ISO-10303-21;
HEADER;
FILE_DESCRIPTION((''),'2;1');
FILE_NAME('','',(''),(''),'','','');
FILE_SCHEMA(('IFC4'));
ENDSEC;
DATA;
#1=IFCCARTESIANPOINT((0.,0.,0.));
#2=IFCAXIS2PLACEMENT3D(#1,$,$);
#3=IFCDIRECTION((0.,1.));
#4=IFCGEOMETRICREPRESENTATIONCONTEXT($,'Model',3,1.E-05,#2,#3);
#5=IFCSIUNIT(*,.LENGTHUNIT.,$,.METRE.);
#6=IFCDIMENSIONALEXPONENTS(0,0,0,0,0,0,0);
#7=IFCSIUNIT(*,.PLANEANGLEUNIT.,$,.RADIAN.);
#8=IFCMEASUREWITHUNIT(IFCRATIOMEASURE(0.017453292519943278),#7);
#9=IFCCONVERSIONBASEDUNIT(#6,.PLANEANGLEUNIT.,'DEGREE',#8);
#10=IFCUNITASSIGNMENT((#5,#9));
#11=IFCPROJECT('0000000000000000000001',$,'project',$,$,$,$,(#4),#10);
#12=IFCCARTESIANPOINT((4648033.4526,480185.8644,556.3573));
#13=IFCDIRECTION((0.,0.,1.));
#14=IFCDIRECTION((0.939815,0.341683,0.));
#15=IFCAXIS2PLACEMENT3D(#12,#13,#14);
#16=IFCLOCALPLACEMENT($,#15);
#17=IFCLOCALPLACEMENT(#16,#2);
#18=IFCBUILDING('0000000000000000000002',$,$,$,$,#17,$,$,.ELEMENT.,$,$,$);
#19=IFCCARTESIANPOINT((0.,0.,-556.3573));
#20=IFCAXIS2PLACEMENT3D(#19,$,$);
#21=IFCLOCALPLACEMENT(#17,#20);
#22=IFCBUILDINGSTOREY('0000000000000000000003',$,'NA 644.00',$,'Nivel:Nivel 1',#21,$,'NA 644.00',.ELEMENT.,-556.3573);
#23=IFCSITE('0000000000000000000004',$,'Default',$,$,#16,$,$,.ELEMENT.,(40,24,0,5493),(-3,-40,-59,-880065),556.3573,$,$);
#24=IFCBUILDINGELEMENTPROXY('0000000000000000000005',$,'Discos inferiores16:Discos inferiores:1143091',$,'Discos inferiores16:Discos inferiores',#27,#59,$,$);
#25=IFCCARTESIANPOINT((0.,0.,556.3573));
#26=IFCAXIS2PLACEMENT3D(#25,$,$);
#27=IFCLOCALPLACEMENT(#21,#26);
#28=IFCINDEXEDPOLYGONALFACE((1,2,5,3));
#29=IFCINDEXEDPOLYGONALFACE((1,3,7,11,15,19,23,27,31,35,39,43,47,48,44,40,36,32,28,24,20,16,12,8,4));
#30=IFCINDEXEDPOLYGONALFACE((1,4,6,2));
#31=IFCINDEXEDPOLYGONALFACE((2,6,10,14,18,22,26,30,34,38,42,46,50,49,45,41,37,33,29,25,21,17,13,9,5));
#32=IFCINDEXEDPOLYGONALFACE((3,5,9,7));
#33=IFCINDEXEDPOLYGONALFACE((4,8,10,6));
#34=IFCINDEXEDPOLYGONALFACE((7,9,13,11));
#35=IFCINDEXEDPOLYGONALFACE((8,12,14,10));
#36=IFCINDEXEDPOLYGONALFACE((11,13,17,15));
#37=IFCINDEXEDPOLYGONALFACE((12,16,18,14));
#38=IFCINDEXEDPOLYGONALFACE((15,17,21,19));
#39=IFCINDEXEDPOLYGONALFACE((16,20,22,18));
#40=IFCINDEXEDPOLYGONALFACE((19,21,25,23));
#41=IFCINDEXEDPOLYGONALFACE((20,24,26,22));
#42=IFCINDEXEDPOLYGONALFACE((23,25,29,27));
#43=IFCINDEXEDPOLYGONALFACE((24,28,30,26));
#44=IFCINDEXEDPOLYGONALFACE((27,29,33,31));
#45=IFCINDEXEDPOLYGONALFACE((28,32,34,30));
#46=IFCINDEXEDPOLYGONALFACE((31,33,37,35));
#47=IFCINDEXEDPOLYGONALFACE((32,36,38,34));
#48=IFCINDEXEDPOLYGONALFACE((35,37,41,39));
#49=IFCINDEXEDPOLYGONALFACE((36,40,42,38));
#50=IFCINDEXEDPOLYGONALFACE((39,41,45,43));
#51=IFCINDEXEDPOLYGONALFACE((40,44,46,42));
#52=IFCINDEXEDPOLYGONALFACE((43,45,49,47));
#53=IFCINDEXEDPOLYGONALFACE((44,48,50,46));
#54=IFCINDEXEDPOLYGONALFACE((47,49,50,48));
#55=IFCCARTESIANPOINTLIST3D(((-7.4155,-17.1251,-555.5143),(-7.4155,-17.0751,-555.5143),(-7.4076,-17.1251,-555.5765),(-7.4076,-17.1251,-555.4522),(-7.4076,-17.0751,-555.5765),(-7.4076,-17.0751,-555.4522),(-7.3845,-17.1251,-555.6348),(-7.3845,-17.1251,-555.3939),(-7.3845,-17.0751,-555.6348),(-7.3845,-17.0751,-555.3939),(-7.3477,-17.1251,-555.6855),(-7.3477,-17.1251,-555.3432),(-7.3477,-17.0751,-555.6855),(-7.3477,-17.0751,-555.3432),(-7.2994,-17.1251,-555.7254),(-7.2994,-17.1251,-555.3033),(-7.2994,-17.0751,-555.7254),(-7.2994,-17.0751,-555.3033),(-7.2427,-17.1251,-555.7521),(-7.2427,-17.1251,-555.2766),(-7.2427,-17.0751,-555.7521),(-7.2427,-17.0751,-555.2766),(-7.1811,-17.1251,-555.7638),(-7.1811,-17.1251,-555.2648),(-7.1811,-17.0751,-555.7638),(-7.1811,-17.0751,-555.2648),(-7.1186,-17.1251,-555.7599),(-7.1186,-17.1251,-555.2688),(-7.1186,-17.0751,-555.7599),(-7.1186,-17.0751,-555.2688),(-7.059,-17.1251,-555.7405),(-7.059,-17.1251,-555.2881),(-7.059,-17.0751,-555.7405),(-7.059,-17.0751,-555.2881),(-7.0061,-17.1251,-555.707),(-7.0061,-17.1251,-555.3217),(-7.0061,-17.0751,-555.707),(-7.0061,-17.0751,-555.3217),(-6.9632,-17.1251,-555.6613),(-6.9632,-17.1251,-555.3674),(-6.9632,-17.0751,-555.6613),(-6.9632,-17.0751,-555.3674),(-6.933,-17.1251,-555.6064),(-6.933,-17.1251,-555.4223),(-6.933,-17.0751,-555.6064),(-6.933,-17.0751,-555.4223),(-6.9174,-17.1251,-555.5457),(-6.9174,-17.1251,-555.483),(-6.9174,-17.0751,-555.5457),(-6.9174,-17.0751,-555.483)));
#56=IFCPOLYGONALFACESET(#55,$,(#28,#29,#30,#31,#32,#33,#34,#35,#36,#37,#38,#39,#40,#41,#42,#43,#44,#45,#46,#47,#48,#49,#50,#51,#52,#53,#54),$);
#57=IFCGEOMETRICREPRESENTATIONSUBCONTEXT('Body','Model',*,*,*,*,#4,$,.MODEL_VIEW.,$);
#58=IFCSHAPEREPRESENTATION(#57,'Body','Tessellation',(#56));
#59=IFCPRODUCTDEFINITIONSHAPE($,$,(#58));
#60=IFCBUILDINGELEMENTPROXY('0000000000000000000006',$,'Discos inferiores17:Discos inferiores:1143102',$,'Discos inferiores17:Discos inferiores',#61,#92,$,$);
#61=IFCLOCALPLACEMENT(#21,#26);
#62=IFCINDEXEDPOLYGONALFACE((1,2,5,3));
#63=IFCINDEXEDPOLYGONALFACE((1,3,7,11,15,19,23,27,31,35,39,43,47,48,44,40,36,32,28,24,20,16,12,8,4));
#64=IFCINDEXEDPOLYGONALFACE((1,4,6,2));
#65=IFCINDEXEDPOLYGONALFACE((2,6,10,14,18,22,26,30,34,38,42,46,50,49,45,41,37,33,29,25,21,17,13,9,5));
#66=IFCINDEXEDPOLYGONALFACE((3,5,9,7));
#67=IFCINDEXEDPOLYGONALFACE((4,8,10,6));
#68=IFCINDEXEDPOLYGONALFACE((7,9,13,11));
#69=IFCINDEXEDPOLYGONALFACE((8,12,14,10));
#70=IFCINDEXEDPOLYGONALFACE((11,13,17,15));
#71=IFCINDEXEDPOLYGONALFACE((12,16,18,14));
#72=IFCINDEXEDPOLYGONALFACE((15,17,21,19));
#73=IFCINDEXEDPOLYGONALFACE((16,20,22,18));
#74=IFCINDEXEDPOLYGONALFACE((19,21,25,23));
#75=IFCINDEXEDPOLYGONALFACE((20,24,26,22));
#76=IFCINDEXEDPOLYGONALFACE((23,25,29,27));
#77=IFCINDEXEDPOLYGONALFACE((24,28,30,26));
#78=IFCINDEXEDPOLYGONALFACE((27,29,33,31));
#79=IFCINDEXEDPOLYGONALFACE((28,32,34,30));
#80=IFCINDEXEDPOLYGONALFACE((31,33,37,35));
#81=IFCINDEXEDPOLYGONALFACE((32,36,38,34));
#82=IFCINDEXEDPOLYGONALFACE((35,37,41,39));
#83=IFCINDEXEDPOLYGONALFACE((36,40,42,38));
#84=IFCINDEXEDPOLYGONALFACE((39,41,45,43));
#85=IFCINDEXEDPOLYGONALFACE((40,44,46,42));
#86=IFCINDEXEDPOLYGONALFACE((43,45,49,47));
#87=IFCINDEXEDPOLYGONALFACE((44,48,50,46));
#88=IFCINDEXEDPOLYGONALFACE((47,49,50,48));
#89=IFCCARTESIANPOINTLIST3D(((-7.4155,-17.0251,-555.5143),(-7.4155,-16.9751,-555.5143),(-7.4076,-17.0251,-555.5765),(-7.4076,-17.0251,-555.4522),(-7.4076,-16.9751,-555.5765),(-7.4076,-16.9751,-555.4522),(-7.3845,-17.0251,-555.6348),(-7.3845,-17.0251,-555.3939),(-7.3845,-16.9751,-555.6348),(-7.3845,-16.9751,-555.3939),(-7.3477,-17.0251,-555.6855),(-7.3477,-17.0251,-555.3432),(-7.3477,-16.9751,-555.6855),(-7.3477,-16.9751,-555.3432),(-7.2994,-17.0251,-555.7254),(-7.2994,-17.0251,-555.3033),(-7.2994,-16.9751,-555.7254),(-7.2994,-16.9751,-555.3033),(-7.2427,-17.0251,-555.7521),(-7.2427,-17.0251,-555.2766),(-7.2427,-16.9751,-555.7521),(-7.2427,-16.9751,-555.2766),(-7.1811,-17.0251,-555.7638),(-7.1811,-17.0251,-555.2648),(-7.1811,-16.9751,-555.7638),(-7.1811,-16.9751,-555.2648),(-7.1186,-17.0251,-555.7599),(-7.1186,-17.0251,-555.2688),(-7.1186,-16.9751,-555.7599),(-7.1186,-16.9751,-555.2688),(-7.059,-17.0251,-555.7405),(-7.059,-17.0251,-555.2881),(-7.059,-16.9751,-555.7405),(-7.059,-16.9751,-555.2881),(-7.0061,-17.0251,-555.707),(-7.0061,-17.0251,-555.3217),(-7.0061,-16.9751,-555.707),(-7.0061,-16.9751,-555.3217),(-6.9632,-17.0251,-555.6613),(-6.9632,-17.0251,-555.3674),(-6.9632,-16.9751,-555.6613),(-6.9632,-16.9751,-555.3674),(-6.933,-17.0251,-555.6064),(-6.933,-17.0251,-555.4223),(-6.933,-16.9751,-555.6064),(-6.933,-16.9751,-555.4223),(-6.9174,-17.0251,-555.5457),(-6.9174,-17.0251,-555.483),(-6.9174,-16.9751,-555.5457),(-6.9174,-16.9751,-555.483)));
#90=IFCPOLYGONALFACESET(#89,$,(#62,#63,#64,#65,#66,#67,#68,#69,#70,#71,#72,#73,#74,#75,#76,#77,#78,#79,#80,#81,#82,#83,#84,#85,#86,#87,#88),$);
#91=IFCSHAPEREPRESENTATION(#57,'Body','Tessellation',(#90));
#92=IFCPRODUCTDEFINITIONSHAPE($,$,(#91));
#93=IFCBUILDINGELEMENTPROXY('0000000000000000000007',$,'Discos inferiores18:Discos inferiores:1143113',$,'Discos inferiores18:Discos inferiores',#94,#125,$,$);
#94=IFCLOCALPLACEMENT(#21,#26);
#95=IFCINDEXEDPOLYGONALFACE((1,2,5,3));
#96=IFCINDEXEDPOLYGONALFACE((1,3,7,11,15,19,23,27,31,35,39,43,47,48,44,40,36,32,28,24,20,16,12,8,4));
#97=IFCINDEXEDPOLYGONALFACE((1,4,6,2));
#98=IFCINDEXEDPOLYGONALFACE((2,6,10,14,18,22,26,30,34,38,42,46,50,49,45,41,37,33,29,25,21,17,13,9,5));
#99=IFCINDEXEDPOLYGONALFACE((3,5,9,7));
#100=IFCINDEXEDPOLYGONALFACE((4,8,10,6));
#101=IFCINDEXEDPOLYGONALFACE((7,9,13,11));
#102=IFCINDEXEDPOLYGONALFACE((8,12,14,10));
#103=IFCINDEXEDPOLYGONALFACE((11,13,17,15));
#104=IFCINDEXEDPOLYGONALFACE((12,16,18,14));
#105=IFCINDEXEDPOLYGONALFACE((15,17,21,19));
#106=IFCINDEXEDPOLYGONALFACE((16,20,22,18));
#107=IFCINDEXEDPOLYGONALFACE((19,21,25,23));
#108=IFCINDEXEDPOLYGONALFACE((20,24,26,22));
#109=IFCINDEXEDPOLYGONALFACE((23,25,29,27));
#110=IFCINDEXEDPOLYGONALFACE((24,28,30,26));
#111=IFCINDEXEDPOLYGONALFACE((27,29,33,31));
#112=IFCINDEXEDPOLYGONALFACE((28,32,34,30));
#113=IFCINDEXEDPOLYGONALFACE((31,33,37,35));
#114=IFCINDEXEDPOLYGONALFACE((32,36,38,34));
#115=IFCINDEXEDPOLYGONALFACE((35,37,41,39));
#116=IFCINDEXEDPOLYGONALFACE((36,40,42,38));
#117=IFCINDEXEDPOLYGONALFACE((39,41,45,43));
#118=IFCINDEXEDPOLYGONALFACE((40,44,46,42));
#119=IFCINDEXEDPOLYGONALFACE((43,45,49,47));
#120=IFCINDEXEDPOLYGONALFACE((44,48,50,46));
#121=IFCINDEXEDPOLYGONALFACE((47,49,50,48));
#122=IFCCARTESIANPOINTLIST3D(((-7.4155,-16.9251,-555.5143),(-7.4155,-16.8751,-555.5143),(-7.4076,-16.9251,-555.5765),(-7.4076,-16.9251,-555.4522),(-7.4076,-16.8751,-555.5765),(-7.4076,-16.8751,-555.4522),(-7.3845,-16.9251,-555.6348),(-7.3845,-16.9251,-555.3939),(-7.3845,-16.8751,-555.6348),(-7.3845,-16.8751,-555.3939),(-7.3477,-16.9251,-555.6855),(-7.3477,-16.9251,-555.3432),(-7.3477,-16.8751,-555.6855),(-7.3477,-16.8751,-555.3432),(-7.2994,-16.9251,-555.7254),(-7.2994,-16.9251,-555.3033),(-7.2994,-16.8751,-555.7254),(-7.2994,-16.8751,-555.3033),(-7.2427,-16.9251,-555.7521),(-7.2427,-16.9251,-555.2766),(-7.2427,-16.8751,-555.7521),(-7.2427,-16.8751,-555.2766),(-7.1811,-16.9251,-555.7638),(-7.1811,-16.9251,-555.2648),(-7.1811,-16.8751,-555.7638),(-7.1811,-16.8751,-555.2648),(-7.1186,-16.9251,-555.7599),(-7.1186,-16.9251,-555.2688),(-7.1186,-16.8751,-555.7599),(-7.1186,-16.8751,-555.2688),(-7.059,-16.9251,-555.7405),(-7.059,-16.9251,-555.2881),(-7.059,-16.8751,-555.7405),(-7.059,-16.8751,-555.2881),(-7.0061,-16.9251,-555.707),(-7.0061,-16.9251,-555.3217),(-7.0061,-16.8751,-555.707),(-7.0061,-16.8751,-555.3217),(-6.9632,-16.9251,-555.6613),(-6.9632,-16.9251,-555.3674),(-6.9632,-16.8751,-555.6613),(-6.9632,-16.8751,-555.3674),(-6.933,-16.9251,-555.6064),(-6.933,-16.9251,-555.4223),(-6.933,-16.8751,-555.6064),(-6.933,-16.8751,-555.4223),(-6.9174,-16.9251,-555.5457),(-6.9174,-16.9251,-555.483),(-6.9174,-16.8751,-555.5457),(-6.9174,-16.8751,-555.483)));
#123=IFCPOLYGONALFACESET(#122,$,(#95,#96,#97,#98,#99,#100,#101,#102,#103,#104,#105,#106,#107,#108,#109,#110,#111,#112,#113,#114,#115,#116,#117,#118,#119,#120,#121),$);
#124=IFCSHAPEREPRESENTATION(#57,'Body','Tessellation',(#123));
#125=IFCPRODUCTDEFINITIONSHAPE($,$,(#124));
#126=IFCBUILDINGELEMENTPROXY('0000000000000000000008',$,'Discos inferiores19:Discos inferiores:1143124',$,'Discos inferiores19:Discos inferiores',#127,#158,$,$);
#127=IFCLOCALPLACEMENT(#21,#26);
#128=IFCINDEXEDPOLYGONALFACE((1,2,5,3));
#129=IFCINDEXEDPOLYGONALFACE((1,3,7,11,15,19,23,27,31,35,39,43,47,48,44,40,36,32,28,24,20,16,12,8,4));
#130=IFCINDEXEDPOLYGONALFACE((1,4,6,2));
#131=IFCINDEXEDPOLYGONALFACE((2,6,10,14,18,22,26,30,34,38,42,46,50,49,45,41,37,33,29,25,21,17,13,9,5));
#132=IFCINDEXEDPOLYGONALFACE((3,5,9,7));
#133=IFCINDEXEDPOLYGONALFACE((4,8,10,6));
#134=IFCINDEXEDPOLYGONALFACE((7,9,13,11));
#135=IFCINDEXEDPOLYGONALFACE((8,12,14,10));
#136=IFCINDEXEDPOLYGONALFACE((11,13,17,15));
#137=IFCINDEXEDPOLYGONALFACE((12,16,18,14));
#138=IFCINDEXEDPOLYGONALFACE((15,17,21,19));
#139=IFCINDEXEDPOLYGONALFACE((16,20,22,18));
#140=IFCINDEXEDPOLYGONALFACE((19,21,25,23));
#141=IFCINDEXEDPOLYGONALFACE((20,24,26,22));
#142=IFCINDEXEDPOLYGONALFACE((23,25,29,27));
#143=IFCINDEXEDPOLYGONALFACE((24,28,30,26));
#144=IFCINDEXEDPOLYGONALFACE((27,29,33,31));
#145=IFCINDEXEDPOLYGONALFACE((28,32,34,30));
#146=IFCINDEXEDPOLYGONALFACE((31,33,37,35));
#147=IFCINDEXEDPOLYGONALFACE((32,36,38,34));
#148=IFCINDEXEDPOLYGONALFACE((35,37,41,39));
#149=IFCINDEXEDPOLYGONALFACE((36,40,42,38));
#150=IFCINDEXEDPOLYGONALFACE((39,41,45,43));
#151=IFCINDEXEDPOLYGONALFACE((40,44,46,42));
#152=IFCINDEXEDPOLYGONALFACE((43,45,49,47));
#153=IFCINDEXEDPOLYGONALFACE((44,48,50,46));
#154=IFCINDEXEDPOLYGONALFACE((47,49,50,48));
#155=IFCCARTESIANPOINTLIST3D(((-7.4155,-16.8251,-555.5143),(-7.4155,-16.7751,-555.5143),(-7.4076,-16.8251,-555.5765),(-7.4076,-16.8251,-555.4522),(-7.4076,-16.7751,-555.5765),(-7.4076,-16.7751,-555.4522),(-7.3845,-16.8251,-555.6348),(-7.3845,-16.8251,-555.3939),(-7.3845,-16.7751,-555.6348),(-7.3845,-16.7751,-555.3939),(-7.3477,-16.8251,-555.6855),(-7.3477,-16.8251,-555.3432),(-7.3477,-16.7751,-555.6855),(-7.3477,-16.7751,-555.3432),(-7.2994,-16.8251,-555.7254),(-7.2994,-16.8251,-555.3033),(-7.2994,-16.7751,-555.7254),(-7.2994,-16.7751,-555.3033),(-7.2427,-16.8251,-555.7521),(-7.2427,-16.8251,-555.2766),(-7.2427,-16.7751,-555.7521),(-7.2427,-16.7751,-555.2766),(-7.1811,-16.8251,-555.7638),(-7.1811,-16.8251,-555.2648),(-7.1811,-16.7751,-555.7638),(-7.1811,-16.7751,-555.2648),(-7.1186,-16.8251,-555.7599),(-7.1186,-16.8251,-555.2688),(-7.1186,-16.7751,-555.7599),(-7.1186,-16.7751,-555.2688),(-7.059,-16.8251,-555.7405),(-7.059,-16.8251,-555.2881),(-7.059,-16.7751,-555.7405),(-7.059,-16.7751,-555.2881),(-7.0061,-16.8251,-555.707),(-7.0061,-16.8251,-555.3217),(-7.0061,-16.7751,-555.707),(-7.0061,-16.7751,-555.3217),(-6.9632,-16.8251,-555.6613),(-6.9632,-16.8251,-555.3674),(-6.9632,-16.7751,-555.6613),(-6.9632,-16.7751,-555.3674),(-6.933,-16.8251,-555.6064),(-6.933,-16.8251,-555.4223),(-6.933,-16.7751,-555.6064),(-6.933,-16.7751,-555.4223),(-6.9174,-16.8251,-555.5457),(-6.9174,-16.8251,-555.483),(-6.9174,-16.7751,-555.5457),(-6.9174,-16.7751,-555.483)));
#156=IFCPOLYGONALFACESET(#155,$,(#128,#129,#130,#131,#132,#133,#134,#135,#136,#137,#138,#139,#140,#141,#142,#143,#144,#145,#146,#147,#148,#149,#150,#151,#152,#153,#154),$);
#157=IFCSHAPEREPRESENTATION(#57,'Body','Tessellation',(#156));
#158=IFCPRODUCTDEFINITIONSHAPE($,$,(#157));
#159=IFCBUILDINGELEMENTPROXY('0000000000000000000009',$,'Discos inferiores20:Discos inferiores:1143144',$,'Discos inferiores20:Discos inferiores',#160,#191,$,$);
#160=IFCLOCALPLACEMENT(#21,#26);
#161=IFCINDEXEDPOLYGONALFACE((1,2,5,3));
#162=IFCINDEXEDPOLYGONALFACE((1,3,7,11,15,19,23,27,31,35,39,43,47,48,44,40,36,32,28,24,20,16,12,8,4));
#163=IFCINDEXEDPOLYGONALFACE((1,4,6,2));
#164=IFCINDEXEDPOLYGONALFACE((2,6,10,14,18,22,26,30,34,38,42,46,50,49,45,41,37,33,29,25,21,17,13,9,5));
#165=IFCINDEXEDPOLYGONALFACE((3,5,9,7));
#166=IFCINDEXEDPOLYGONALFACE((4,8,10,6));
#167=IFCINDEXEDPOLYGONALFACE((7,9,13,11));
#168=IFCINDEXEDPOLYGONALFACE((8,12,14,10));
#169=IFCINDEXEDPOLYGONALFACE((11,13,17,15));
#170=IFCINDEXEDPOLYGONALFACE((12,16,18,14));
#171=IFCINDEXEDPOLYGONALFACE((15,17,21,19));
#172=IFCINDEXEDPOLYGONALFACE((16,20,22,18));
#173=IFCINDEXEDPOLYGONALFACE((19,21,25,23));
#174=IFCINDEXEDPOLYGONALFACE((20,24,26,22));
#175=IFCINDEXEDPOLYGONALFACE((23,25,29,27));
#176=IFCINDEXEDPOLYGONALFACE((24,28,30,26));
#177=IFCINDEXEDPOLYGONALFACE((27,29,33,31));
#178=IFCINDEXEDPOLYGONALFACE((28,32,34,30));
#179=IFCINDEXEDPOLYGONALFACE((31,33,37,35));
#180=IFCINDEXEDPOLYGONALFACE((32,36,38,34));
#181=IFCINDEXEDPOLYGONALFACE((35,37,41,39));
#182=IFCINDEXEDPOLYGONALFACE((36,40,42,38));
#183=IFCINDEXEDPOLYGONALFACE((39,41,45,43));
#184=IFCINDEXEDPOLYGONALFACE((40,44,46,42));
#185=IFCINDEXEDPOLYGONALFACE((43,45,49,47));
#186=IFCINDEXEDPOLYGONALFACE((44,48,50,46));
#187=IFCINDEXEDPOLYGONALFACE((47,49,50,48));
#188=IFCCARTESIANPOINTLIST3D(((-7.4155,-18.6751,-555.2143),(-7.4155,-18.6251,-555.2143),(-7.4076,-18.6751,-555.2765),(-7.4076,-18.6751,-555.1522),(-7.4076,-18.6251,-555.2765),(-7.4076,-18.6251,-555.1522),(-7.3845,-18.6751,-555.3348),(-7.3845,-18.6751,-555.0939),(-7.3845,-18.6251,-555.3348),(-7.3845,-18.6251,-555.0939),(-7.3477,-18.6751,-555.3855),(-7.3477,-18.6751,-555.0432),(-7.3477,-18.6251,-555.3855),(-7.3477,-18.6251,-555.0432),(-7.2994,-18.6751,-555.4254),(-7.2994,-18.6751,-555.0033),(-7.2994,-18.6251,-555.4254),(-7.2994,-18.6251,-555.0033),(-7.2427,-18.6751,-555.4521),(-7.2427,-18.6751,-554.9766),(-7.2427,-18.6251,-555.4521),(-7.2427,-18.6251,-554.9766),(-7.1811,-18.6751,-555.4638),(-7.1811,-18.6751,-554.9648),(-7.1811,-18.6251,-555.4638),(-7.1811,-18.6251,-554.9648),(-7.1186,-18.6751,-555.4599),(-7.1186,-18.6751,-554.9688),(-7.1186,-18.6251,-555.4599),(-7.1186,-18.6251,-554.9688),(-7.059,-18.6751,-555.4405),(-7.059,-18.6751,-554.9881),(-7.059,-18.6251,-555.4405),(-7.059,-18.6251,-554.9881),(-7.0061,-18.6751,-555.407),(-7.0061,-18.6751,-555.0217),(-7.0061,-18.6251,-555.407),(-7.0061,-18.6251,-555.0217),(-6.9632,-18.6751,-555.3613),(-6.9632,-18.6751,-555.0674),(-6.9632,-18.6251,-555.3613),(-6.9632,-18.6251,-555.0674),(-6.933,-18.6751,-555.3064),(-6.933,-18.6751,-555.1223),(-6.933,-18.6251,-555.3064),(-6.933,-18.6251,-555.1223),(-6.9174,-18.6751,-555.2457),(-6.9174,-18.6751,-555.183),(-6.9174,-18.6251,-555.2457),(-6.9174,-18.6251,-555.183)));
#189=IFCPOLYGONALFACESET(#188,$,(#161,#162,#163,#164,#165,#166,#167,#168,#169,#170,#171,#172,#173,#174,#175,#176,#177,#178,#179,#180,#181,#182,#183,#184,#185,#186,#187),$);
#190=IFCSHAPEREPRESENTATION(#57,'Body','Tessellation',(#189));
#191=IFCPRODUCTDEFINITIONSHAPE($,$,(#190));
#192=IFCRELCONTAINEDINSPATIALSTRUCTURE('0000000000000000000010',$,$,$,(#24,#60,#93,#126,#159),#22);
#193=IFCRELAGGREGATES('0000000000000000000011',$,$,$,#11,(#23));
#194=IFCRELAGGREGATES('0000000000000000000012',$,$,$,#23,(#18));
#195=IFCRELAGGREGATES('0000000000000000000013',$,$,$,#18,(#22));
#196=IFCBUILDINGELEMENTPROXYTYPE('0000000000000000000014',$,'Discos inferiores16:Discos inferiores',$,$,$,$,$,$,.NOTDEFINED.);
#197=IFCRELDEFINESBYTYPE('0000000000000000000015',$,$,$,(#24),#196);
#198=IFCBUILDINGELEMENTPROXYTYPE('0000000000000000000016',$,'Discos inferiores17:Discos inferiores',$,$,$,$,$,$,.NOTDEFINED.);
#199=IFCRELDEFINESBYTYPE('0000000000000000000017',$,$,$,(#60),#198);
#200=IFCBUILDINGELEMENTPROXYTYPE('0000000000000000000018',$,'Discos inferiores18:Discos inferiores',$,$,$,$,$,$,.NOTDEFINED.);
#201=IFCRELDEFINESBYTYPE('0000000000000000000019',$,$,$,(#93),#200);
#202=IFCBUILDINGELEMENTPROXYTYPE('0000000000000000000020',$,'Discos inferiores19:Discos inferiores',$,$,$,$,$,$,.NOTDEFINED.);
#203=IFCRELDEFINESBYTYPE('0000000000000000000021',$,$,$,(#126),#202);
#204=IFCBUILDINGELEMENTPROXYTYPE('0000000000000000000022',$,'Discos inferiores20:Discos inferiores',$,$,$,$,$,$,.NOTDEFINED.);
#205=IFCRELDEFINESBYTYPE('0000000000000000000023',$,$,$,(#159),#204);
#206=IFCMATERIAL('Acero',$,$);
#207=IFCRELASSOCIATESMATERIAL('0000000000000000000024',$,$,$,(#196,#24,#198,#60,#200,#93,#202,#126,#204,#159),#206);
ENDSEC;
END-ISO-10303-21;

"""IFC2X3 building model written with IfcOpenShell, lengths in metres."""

from ifc_helpers import new_model, entity, si_unit, converted_unit, direction, frame, origin, origin_2d_with_axis, place, context, subcontext, project, spatial, circle, extrude, source, transform, mapped, material, type_object, type_shapes, element, save


model = new_model("IFC2X3")

# Units and contexts
model_context = context("Model", 3, precision=1e-05, world=origin(), true_north=direction((0.0, 1.0)))
body_context = subcontext(model_context, "Body", "Model", "MODEL_VIEW")
ifc_project = project(units=[si_unit("LENGTHUNIT", "METRE"), converted_unit("PLANEANGLEUNIT", "DEGREE", entity("IfcRatioMeasure", 0.017453292519943278), si_unit("PLANEANGLEUNIT", "RADIAN"), dimensions=[0, 0, 0, 0, 0, 0, 0])], contexts=[model_context])

# Site, building, storey
site_placement = place(None, frame((4648033.4526, 480185.8644, 556.3573), z_axis=(0.0, 0.0, 1.0), x_axis=(0.939815, 0.341683, 0.0)))
site = spatial("IfcSite", under=ifc_project, at=site_placement, Name="Default", CompositionType="ELEMENT", RefLatitude=(40, 24, 0, 5493), RefLongitude=(-3, -40, -59, -880065), RefElevation=556.3573)
building_placement = place(site_placement, origin())
building = spatial("IfcBuilding", under=site, at=building_placement, CompositionType="ELEMENT")
storey_placement = place(building_placement, frame((0.0, 0.0, -556.3573)))
storey = spatial("IfcBuildingStorey", under=building, at=storey_placement, Name="NA 644.00", ObjectType="Nivel:Nivel 1", LongName="NA 644.00", CompositionType="ELEMENT", Elevation=-556.3573)

# Building element proxies
ifc_material_1 = material(Name="Acero")
building_element_proxy_type_1 = type_object("IfcBuildingElementProxyType", Name="Discos inferiores16:Discos inferiores", PredefinedType="NOTDEFINED", material=ifc_material_1)
shared_shape_1 = source(origin(), body_context, "Body", "SweptSolid", [
    extrude(circle(Radius=0.25, at=origin_2d_with_axis()), frame((-7.1655, -17.1251, -555.5143), z_axis=(0.0, 1.0, 0.0), x_axis=(-1.0, 0.0, 0.0)), (0.0, 0.0, 1.0), 0.05),
])
type_shapes(building_element_proxy_type_1, [shared_shape_1])
proxy_1_placement = place(storey_placement, frame((0.0, 0.0, 556.3573)))
element("IfcBuildingElementProxy", 1, at=proxy_1_placement, inside=storey, type_object=building_element_proxy_type_1, material=ifc_material_1, Name="Discos inferiores16:Discos inferiores:1143091", ObjectType="Discos inferiores16:Discos inferiores", context=body_context, shape_type="MappedRepresentation", body=[
    mapped(shared_shape_1, transform((0.0, 0.0, 0.0), scale=1.0)),
])
building_element_proxy_type_2 = type_object("IfcBuildingElementProxyType", Name="Discos inferiores17:Discos inferiores", PredefinedType="NOTDEFINED", material=ifc_material_1)
shared_shape_2 = source(origin(), body_context, "Body", "SweptSolid", [
    extrude(circle(Radius=0.25, at=origin_2d_with_axis()), frame((-7.1655, -17.0251, -555.5143), z_axis=(0.0, 1.0, 0.0), x_axis=(-1.0, 0.0, 0.0)), (0.0, 0.0, 1.0), 0.05),
])
type_shapes(building_element_proxy_type_2, [shared_shape_2])
proxy_2_placement = place(storey_placement, frame((0.0, 0.0, 556.3573)))
element("IfcBuildingElementProxy", 2, at=proxy_2_placement, inside=storey, type_object=building_element_proxy_type_2, material=ifc_material_1, Name="Discos inferiores17:Discos inferiores:1143102", ObjectType="Discos inferiores17:Discos inferiores", context=body_context, shape_type="MappedRepresentation", body=[
    mapped(shared_shape_2, transform((0.0, 0.0, 0.0), scale=1.0)),
])
building_element_proxy_type_3 = type_object("IfcBuildingElementProxyType", Name="Discos inferiores18:Discos inferiores", PredefinedType="NOTDEFINED", material=ifc_material_1)
shared_shape_3 = source(origin(), body_context, "Body", "SweptSolid", [
    extrude(circle(Radius=0.25, at=origin_2d_with_axis()), frame((-7.1655, -16.9251, -555.5143), z_axis=(0.0, 1.0, 0.0), x_axis=(-1.0, 0.0, 0.0)), (0.0, 0.0, 1.0), 0.05),
])
type_shapes(building_element_proxy_type_3, [shared_shape_3])
proxy_3_placement = place(storey_placement, frame((0.0, 0.0, 556.3573)))
element("IfcBuildingElementProxy", 3, at=proxy_3_placement, inside=storey, type_object=building_element_proxy_type_3, material=ifc_material_1, Name="Discos inferiores18:Discos inferiores:1143113", ObjectType="Discos inferiores18:Discos inferiores", context=body_context, shape_type="MappedRepresentation", body=[
    mapped(shared_shape_3, transform((0.0, 0.0, 0.0), scale=1.0)),
])
building_element_proxy_type_4 = type_object("IfcBuildingElementProxyType", Name="Discos inferiores19:Discos inferiores", PredefinedType="NOTDEFINED", material=ifc_material_1)
shared_shape_4 = source(origin(), body_context, "Body", "SweptSolid", [
    extrude(circle(Radius=0.25, at=origin_2d_with_axis()), frame((-7.1655, -16.8251, -555.5143), z_axis=(0.0, 1.0, 0.0), x_axis=(-1.0, 0.0, 0.0)), (0.0, 0.0, 1.0), 0.05),
])
type_shapes(building_element_proxy_type_4, [shared_shape_4])
proxy_4_placement = place(storey_placement, frame((0.0, 0.0, 556.3573)))
element("IfcBuildingElementProxy", 4, at=proxy_4_placement, inside=storey, type_object=building_element_proxy_type_4, material=ifc_material_1, Name="Discos inferiores19:Discos inferiores:1143124", ObjectType="Discos inferiores19:Discos inferiores", context=body_context, shape_type="MappedRepresentation", body=[
    mapped(shared_shape_4, transform((0.0, 0.0, 0.0), scale=1.0)),
])
building_element_proxy_type_5 = type_object("IfcBuildingElementProxyType", Name="Discos inferiores20:Discos inferiores", PredefinedType="NOTDEFINED", material=ifc_material_1)
shared_shape_5 = source(origin(), body_context, "Body", "SweptSolid", [
    extrude(circle(Radius=0.25, at=origin_2d_with_axis()), frame((-7.1655, -18.6751, -555.2143), z_axis=(0.0, 1.0, 0.0), x_axis=(-1.0, 0.0, 0.0)), (0.0, 0.0, 1.0), 0.05),
])
type_shapes(building_element_proxy_type_5, [shared_shape_5])
proxy_5_placement = place(storey_placement, frame((0.0, 0.0, 556.3573)))
element("IfcBuildingElementProxy", 5, at=proxy_5_placement, inside=storey, type_object=building_element_proxy_type_5, material=ifc_material_1, Name="Discos inferiores20:Discos inferiores:1143144", ObjectType="Discos inferiores20:Discos inferiores", context=body_context, shape_type="MappedRepresentation", body=[
    mapped(shared_shape_5, transform((0.0, 0.0, 0.0), scale=1.0)),
])

save(model, "model.ifc")
